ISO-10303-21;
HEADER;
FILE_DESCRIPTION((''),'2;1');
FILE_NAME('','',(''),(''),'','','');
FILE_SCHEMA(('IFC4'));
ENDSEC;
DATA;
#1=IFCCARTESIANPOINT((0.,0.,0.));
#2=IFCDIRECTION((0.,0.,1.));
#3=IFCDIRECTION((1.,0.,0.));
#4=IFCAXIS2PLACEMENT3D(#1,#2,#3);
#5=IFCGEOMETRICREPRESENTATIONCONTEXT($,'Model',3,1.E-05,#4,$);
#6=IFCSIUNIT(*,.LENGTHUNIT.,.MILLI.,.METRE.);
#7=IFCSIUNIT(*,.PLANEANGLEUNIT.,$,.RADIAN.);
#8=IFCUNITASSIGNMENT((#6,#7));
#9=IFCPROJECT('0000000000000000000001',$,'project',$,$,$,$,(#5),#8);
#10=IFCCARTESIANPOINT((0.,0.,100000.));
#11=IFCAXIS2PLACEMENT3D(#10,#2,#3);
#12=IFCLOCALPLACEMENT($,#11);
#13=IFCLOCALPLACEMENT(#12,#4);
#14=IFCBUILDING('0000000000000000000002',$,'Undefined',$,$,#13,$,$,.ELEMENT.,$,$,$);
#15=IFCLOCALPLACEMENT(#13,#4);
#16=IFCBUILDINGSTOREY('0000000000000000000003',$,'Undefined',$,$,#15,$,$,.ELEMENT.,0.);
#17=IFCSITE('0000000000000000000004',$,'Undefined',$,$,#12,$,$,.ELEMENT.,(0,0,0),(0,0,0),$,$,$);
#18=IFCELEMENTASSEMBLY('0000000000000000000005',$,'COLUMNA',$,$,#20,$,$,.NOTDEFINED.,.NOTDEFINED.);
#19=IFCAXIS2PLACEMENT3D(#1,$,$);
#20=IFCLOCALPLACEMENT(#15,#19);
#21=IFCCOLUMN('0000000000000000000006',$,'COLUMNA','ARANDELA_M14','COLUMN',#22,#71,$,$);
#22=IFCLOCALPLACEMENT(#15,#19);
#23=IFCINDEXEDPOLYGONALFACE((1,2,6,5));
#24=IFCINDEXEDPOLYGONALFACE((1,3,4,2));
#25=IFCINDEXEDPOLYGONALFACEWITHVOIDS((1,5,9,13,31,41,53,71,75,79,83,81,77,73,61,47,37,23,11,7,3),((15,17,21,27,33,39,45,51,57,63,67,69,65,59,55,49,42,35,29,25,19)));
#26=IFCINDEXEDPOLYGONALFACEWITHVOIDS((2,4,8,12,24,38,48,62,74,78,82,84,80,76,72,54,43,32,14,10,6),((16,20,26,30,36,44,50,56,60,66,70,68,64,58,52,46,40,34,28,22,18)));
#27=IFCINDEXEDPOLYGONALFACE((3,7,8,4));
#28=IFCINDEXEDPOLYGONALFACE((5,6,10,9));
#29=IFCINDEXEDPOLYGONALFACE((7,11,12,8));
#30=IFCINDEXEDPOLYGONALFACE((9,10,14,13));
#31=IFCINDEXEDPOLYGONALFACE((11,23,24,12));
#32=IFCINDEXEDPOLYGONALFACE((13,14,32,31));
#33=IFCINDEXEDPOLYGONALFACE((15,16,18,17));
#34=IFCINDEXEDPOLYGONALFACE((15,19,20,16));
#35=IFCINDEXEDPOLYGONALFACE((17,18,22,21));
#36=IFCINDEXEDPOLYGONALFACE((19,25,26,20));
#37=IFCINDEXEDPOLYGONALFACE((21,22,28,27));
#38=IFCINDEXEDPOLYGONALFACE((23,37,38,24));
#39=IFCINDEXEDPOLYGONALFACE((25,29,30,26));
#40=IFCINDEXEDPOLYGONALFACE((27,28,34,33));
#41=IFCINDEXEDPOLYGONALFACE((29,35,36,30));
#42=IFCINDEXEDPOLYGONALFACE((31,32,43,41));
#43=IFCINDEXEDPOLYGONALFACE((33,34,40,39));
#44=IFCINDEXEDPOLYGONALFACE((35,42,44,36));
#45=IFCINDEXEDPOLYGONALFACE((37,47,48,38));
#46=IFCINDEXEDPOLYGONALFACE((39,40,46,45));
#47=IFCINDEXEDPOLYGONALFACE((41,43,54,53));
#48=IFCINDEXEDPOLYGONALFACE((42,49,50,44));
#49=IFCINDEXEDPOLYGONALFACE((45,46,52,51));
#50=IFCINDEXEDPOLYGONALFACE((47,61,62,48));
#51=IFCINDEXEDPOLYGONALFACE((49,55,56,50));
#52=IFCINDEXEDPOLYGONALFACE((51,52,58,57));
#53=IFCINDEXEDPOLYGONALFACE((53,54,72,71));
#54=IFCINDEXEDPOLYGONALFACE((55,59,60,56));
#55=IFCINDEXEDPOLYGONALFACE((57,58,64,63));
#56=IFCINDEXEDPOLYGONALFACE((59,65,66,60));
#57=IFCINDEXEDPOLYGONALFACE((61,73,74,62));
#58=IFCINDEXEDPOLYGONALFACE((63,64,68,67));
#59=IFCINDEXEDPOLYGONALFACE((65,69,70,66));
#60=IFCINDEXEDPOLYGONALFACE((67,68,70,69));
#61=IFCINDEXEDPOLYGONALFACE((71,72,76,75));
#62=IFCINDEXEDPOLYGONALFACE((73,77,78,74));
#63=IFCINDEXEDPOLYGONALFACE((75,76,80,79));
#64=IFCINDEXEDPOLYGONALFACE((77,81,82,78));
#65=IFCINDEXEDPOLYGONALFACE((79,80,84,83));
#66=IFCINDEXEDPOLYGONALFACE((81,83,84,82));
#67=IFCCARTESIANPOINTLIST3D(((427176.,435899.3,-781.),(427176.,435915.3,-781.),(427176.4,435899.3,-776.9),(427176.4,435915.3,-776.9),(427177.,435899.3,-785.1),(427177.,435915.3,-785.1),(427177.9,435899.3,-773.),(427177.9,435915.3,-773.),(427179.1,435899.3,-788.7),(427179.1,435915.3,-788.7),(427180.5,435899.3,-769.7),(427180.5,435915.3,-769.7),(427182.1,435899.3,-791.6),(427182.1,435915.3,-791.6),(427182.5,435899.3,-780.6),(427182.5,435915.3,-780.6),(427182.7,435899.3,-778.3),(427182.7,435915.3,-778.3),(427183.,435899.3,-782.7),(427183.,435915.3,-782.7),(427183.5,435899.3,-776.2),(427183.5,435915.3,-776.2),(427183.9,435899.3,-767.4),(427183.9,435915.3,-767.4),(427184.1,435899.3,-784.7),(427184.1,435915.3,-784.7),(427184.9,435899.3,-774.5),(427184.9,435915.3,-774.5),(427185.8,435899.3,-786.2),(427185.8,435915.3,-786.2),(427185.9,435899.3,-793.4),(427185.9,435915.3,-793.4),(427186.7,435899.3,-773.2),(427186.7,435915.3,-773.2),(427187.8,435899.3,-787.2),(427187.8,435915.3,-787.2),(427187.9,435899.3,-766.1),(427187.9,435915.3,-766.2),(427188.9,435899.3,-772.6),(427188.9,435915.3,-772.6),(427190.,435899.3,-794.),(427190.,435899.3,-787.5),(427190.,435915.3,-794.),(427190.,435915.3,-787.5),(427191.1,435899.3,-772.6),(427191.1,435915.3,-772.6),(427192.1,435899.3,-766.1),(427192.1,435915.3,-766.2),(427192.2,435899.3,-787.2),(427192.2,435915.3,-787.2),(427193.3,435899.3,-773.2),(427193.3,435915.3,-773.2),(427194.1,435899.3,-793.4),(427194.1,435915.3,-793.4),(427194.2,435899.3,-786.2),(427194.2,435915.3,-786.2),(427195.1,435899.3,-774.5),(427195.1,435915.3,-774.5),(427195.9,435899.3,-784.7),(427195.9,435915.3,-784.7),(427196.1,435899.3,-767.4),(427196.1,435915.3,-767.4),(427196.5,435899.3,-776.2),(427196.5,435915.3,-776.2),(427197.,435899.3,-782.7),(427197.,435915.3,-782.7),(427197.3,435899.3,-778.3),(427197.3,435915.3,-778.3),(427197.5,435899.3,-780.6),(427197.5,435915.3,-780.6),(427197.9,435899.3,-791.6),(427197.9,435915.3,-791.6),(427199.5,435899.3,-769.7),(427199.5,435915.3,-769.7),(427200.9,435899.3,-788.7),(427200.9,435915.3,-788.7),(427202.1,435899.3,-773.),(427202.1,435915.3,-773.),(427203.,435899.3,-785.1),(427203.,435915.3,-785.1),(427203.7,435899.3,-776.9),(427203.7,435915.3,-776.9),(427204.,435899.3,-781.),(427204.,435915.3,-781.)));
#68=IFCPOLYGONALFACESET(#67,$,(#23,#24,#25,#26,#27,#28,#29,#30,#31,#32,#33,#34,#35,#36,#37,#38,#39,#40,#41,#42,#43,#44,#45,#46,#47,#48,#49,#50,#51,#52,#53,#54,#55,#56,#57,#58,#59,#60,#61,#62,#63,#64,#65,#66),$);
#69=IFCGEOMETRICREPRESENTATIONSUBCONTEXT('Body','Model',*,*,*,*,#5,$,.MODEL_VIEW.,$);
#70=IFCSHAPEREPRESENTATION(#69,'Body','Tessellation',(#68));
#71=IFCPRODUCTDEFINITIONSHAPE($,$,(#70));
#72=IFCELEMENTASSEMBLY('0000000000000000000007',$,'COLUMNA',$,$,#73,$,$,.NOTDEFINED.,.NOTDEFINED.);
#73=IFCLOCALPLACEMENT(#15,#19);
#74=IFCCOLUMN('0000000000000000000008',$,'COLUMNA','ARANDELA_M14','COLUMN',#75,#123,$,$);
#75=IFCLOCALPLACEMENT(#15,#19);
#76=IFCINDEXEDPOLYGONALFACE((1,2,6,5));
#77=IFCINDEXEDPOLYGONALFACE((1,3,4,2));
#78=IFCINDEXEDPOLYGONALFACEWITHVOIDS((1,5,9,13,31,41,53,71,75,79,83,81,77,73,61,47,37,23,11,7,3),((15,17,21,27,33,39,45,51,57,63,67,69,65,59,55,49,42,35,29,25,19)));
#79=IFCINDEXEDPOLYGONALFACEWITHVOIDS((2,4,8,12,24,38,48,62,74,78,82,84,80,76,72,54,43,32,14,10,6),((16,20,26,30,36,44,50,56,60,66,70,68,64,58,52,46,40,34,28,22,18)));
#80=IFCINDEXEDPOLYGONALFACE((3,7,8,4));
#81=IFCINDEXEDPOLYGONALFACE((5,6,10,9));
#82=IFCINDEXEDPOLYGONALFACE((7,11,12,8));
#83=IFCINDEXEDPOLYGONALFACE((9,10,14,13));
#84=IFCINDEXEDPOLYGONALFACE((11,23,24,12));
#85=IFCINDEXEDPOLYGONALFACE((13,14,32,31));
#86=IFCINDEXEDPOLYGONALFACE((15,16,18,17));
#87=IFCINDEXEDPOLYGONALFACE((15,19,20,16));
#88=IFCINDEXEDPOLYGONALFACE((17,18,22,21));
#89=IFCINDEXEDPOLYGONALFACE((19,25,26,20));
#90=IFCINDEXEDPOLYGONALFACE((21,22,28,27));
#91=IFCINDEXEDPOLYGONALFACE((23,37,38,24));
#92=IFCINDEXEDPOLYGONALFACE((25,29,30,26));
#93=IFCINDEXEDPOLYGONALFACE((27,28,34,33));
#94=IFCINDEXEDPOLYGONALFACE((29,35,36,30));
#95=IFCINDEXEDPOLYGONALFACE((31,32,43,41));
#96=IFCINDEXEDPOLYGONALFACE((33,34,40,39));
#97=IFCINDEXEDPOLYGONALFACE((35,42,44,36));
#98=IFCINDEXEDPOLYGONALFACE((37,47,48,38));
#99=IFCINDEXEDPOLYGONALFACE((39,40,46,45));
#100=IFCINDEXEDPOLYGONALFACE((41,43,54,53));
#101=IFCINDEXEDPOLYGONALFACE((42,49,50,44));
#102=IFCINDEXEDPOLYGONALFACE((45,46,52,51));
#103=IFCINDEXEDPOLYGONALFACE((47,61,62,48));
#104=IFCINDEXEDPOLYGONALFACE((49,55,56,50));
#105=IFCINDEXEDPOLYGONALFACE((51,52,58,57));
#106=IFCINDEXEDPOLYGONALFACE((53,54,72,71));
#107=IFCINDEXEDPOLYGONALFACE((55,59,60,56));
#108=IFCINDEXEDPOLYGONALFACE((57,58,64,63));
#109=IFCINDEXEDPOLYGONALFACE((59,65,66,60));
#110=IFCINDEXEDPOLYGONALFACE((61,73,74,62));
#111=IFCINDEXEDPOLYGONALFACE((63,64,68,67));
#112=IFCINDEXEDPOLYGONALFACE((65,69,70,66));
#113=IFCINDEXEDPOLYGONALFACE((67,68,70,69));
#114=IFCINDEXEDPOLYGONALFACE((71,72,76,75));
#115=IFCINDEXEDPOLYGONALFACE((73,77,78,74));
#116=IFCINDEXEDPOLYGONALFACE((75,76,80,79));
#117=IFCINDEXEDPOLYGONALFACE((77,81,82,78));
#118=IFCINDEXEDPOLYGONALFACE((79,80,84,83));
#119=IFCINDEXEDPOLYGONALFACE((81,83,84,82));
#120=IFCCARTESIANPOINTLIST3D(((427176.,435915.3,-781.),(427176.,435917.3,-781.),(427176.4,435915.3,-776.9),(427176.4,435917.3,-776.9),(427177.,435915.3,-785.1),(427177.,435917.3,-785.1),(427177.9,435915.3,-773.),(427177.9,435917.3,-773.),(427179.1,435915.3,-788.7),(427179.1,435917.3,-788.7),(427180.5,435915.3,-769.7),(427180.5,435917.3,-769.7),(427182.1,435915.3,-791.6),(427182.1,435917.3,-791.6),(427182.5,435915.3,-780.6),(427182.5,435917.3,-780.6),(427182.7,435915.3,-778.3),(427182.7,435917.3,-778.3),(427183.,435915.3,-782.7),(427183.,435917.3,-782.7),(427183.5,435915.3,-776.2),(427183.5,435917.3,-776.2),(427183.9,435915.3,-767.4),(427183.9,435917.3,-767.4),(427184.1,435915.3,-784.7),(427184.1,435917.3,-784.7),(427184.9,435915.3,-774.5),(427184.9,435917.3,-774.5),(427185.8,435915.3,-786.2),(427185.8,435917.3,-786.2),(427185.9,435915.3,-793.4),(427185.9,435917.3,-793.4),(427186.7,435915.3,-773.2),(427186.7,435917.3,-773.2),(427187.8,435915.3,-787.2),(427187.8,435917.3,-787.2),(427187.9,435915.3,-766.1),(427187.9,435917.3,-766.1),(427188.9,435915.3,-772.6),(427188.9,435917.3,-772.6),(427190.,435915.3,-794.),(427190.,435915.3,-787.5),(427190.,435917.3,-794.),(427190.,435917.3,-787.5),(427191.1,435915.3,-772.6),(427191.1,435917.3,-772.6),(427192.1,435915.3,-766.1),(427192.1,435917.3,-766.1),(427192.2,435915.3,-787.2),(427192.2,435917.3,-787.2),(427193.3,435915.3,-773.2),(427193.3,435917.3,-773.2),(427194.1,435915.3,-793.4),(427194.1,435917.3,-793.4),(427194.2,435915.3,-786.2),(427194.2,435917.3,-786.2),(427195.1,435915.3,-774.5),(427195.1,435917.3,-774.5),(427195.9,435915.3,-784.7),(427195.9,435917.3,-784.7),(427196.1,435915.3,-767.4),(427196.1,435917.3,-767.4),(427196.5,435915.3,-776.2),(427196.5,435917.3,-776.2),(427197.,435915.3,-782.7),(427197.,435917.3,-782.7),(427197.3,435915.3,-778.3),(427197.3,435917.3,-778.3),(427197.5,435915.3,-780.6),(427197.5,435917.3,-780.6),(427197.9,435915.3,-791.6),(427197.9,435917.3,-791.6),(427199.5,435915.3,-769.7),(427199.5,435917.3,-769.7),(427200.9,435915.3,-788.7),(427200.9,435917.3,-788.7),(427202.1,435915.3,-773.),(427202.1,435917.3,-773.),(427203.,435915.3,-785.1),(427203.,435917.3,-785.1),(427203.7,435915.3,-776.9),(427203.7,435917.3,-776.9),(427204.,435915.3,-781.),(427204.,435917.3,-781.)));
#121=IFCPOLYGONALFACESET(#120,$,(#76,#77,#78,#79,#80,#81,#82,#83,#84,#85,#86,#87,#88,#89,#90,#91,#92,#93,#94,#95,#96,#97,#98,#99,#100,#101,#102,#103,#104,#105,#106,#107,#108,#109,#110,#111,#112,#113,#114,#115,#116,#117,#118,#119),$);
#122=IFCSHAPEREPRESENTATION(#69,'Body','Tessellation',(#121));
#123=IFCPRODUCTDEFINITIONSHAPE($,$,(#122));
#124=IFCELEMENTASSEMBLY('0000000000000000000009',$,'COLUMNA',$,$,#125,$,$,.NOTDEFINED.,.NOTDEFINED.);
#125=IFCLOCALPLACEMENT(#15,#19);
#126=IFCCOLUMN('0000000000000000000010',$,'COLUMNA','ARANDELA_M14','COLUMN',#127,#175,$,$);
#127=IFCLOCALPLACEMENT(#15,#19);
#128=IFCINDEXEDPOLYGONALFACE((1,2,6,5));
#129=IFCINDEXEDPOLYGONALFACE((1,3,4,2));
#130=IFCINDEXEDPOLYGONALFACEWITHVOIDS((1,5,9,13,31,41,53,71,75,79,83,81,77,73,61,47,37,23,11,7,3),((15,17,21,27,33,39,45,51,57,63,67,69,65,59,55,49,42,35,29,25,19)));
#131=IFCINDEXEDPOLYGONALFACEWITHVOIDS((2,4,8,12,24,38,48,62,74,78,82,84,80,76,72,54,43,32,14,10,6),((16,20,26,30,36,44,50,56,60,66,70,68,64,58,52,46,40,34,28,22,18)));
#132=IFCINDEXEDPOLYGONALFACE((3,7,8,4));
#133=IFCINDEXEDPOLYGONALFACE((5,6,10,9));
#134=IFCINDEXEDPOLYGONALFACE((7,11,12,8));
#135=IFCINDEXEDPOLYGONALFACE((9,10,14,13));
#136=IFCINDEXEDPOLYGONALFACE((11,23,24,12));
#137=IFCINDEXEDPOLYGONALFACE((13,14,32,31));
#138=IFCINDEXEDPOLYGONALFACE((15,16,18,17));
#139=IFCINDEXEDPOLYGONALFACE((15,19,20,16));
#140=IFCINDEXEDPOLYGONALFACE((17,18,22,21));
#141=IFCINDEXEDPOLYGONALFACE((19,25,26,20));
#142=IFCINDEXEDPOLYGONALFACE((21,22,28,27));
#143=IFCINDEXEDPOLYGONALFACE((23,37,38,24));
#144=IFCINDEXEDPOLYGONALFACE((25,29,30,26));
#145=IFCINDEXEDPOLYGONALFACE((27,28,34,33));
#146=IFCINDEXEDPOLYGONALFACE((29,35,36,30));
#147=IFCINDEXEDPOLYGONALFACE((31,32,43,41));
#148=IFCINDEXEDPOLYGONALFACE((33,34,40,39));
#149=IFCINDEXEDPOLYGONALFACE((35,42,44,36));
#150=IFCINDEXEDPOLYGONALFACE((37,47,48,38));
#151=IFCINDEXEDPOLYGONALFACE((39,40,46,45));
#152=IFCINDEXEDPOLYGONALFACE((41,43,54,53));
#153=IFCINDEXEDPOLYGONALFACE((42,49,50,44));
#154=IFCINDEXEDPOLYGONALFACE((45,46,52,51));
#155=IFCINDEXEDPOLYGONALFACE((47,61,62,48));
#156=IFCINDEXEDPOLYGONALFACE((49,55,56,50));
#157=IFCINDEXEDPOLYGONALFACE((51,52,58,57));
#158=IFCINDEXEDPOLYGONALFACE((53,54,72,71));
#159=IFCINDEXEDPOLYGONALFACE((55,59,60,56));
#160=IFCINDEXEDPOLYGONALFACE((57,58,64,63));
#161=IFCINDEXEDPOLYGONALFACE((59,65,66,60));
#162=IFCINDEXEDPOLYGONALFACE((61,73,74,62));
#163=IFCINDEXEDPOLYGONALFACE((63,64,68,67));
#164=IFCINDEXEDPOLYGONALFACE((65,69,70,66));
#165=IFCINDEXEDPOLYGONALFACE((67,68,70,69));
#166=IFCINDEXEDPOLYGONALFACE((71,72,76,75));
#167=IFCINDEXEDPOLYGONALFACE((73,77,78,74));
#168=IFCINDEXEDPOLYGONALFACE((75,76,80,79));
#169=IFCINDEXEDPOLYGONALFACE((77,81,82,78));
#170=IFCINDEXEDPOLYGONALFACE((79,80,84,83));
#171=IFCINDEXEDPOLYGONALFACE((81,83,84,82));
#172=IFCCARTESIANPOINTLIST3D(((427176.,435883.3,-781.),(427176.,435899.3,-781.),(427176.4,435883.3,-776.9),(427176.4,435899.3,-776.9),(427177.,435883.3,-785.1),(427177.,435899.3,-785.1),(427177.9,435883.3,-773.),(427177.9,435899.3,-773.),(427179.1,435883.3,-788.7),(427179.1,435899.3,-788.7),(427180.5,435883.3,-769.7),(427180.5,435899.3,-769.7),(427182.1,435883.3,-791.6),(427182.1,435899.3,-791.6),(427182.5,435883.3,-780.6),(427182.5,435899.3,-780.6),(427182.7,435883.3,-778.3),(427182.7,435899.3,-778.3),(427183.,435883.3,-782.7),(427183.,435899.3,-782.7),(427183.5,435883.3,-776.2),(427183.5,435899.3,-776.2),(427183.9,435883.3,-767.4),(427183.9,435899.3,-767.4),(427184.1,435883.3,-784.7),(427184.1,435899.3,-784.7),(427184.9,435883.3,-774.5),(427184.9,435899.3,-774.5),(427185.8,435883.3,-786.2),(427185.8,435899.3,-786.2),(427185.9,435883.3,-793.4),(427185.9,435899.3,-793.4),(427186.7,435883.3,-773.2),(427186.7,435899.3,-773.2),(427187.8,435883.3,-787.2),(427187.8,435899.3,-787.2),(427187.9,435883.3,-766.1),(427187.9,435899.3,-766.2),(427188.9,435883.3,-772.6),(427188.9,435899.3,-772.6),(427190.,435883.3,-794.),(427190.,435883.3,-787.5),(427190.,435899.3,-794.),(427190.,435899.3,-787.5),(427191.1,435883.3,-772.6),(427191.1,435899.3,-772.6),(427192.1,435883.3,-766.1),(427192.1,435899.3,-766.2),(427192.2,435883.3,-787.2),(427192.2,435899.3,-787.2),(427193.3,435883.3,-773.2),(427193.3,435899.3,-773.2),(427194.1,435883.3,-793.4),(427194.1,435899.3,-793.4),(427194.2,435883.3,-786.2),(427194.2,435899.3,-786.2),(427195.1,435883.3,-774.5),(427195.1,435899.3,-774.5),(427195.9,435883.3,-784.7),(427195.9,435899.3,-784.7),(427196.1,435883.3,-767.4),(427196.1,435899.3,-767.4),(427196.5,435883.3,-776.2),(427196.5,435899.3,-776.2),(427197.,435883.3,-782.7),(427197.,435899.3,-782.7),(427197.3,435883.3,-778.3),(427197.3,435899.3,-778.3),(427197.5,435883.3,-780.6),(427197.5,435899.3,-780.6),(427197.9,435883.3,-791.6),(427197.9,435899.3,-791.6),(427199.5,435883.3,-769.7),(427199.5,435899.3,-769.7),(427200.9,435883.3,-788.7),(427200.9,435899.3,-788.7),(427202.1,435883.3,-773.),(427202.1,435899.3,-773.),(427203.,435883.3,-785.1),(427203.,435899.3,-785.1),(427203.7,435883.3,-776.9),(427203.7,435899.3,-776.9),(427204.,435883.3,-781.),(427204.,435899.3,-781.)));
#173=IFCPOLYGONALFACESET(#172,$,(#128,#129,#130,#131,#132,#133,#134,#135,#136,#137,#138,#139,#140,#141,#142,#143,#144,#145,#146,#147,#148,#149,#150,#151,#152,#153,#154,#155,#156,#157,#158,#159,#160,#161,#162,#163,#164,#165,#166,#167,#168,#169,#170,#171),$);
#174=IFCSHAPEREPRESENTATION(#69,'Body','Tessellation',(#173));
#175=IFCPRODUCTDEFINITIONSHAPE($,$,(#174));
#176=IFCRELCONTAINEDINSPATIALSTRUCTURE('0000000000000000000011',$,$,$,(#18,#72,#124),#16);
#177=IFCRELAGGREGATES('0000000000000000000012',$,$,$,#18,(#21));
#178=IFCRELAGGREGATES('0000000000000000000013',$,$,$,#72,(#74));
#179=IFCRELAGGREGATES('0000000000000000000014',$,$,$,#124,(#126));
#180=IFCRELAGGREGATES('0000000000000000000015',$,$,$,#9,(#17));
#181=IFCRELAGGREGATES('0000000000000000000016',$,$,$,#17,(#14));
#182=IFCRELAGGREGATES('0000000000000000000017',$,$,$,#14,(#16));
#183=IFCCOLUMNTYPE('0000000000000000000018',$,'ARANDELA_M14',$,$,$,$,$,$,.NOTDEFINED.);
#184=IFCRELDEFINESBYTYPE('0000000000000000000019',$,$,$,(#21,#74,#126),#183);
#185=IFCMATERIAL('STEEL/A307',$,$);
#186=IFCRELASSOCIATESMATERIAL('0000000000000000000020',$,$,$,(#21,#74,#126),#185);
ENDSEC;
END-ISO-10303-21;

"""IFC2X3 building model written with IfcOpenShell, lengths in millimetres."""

from ifc_helpers import new_model, si_unit, frame, origin_with_axes, origin_2d_with_axis, place, context, subcontext, project, spatial, hollow_circle, extrude, material, type_object, element, aggregate, save


model = new_model("IFC2X3")

# Units and contexts
model_context = context("Model", 3, precision=1e-05, world=origin_with_axes())
body_context = subcontext(model_context, "Body", "Model", "MODEL_VIEW")
ifc_project = project(units=[si_unit("LENGTHUNIT", "METRE", prefix="MILLI"), si_unit("PLANEANGLEUNIT", "RADIAN")], contexts=[model_context])

# Site, building, storey
site_placement = place(None, frame((0.0, 0.0, 100000.0), z_axis=(0.0, 0.0, 1.0), x_axis=(1.0, 0.0, 0.0)))
site = spatial("IfcSite", under=ifc_project, at=site_placement, Name="Undefined", CompositionType="ELEMENT", RefLatitude=(0, 0, 0), RefLongitude=(0, 0, 0))
building_placement = place(site_placement, origin_with_axes())
building = spatial("IfcBuilding", under=site, at=building_placement, Name="Undefined", CompositionType="ELEMENT")
storey_placement = place(building_placement, origin_with_axes())
storey = spatial("IfcBuildingStorey", under=building, at=storey_placement, Name="Undefined", CompositionType="ELEMENT", Elevation=0.0)

# Element assemblies, columns
assembly_1_placement = place(storey_placement, origin_with_axes())
assembly_1 = element("IfcElementAssembly", 1, at=assembly_1_placement, inside=storey, Name="COLUMNA", AssemblyPlace="NOTDEFINED", PredefinedType="NOTDEFINED")
ifc_material_1 = material(Name="STEEL/A307")
column_type = type_object("IfcColumnType", Name="ARANDELA_M14", PredefinedType="NOTDEFINED")
column_1_placement = place(assembly_1_placement, frame((427190.0, 435915.3, -780.0), z_axis=(0.0, -1.0, 0.000285), x_axis=(-1.0, 0.0, 0.0)))
column_1 = element("IfcColumn", 2, at=column_1_placement, type_object=column_type, material=ifc_material_1, Name="COLUMNA", Description="ARANDELA_M14", ObjectType="COLUMN", context=body_context, shape_type="SweptSolid", body=[
    extrude(hollow_circle(Radius=14.0, WallThickness=6.5, at=origin_2d_with_axis()), frame((0.0, 0.0, 16.0), z_axis=(0.0, 0.0, -1.0), x_axis=(0.0, 1.0, 0.0)), (0.0, 0.0, 1.0), 16.0),
])
aggregate(assembly_1, [column_1])
assembly_2_placement = place(storey_placement, origin_with_axes())
assembly_2 = element("IfcElementAssembly", 3, at=assembly_2_placement, inside=storey, Name="COLUMNA", AssemblyPlace="NOTDEFINED", PredefinedType="NOTDEFINED")
column_2_placement = place(assembly_2_placement, frame((427190.0, 435917.3, -780.0), z_axis=(0.0, -1.0, 0.000285), x_axis=(-1.0, 0.0, 0.0)))
column_2 = element("IfcColumn", 4, at=column_2_placement, type_object=column_type, material=ifc_material_1, Name="COLUMNA", Description="ARANDELA_M14", ObjectType="COLUMN", context=body_context, shape_type="SweptSolid", body=[
    extrude(hollow_circle(Radius=14.0, WallThickness=6.5, at=origin_2d_with_axis()), frame((0.0, 0.0, 2.0), z_axis=(0.0, 0.0, -1.0), x_axis=(0.0, 1.0, 0.0)), (0.0, 0.0, 1.0), 2.0),
])
aggregate(assembly_2, [column_2])
assembly_3_placement = place(storey_placement, origin_with_axes())
assembly_3 = element("IfcElementAssembly", 5, at=assembly_3_placement, inside=storey, Name="COLUMNA", AssemblyPlace="NOTDEFINED", PredefinedType="NOTDEFINED")
column_3_placement = place(assembly_3_placement, frame((427190.0, 435899.3, -780.0), z_axis=(0.0, -1.0, 0.000285), x_axis=(-1.0, 0.0, 0.0)))
column_3 = element("IfcColumn", 6, at=column_3_placement, type_object=column_type, material=ifc_material_1, Name="COLUMNA", Description="ARANDELA_M14", ObjectType="COLUMN", context=body_context, shape_type="SweptSolid", body=[
    extrude(hollow_circle(Radius=14.0, WallThickness=6.5, at=origin_2d_with_axis()), frame((0.0, 0.0, 16.0), z_axis=(0.0, 0.0, -1.0), x_axis=(0.0, 1.0, 0.0)), (0.0, 0.0, 1.0), 16.0),
])
aggregate(assembly_3, [column_3])

save(model, "model.ifc")
